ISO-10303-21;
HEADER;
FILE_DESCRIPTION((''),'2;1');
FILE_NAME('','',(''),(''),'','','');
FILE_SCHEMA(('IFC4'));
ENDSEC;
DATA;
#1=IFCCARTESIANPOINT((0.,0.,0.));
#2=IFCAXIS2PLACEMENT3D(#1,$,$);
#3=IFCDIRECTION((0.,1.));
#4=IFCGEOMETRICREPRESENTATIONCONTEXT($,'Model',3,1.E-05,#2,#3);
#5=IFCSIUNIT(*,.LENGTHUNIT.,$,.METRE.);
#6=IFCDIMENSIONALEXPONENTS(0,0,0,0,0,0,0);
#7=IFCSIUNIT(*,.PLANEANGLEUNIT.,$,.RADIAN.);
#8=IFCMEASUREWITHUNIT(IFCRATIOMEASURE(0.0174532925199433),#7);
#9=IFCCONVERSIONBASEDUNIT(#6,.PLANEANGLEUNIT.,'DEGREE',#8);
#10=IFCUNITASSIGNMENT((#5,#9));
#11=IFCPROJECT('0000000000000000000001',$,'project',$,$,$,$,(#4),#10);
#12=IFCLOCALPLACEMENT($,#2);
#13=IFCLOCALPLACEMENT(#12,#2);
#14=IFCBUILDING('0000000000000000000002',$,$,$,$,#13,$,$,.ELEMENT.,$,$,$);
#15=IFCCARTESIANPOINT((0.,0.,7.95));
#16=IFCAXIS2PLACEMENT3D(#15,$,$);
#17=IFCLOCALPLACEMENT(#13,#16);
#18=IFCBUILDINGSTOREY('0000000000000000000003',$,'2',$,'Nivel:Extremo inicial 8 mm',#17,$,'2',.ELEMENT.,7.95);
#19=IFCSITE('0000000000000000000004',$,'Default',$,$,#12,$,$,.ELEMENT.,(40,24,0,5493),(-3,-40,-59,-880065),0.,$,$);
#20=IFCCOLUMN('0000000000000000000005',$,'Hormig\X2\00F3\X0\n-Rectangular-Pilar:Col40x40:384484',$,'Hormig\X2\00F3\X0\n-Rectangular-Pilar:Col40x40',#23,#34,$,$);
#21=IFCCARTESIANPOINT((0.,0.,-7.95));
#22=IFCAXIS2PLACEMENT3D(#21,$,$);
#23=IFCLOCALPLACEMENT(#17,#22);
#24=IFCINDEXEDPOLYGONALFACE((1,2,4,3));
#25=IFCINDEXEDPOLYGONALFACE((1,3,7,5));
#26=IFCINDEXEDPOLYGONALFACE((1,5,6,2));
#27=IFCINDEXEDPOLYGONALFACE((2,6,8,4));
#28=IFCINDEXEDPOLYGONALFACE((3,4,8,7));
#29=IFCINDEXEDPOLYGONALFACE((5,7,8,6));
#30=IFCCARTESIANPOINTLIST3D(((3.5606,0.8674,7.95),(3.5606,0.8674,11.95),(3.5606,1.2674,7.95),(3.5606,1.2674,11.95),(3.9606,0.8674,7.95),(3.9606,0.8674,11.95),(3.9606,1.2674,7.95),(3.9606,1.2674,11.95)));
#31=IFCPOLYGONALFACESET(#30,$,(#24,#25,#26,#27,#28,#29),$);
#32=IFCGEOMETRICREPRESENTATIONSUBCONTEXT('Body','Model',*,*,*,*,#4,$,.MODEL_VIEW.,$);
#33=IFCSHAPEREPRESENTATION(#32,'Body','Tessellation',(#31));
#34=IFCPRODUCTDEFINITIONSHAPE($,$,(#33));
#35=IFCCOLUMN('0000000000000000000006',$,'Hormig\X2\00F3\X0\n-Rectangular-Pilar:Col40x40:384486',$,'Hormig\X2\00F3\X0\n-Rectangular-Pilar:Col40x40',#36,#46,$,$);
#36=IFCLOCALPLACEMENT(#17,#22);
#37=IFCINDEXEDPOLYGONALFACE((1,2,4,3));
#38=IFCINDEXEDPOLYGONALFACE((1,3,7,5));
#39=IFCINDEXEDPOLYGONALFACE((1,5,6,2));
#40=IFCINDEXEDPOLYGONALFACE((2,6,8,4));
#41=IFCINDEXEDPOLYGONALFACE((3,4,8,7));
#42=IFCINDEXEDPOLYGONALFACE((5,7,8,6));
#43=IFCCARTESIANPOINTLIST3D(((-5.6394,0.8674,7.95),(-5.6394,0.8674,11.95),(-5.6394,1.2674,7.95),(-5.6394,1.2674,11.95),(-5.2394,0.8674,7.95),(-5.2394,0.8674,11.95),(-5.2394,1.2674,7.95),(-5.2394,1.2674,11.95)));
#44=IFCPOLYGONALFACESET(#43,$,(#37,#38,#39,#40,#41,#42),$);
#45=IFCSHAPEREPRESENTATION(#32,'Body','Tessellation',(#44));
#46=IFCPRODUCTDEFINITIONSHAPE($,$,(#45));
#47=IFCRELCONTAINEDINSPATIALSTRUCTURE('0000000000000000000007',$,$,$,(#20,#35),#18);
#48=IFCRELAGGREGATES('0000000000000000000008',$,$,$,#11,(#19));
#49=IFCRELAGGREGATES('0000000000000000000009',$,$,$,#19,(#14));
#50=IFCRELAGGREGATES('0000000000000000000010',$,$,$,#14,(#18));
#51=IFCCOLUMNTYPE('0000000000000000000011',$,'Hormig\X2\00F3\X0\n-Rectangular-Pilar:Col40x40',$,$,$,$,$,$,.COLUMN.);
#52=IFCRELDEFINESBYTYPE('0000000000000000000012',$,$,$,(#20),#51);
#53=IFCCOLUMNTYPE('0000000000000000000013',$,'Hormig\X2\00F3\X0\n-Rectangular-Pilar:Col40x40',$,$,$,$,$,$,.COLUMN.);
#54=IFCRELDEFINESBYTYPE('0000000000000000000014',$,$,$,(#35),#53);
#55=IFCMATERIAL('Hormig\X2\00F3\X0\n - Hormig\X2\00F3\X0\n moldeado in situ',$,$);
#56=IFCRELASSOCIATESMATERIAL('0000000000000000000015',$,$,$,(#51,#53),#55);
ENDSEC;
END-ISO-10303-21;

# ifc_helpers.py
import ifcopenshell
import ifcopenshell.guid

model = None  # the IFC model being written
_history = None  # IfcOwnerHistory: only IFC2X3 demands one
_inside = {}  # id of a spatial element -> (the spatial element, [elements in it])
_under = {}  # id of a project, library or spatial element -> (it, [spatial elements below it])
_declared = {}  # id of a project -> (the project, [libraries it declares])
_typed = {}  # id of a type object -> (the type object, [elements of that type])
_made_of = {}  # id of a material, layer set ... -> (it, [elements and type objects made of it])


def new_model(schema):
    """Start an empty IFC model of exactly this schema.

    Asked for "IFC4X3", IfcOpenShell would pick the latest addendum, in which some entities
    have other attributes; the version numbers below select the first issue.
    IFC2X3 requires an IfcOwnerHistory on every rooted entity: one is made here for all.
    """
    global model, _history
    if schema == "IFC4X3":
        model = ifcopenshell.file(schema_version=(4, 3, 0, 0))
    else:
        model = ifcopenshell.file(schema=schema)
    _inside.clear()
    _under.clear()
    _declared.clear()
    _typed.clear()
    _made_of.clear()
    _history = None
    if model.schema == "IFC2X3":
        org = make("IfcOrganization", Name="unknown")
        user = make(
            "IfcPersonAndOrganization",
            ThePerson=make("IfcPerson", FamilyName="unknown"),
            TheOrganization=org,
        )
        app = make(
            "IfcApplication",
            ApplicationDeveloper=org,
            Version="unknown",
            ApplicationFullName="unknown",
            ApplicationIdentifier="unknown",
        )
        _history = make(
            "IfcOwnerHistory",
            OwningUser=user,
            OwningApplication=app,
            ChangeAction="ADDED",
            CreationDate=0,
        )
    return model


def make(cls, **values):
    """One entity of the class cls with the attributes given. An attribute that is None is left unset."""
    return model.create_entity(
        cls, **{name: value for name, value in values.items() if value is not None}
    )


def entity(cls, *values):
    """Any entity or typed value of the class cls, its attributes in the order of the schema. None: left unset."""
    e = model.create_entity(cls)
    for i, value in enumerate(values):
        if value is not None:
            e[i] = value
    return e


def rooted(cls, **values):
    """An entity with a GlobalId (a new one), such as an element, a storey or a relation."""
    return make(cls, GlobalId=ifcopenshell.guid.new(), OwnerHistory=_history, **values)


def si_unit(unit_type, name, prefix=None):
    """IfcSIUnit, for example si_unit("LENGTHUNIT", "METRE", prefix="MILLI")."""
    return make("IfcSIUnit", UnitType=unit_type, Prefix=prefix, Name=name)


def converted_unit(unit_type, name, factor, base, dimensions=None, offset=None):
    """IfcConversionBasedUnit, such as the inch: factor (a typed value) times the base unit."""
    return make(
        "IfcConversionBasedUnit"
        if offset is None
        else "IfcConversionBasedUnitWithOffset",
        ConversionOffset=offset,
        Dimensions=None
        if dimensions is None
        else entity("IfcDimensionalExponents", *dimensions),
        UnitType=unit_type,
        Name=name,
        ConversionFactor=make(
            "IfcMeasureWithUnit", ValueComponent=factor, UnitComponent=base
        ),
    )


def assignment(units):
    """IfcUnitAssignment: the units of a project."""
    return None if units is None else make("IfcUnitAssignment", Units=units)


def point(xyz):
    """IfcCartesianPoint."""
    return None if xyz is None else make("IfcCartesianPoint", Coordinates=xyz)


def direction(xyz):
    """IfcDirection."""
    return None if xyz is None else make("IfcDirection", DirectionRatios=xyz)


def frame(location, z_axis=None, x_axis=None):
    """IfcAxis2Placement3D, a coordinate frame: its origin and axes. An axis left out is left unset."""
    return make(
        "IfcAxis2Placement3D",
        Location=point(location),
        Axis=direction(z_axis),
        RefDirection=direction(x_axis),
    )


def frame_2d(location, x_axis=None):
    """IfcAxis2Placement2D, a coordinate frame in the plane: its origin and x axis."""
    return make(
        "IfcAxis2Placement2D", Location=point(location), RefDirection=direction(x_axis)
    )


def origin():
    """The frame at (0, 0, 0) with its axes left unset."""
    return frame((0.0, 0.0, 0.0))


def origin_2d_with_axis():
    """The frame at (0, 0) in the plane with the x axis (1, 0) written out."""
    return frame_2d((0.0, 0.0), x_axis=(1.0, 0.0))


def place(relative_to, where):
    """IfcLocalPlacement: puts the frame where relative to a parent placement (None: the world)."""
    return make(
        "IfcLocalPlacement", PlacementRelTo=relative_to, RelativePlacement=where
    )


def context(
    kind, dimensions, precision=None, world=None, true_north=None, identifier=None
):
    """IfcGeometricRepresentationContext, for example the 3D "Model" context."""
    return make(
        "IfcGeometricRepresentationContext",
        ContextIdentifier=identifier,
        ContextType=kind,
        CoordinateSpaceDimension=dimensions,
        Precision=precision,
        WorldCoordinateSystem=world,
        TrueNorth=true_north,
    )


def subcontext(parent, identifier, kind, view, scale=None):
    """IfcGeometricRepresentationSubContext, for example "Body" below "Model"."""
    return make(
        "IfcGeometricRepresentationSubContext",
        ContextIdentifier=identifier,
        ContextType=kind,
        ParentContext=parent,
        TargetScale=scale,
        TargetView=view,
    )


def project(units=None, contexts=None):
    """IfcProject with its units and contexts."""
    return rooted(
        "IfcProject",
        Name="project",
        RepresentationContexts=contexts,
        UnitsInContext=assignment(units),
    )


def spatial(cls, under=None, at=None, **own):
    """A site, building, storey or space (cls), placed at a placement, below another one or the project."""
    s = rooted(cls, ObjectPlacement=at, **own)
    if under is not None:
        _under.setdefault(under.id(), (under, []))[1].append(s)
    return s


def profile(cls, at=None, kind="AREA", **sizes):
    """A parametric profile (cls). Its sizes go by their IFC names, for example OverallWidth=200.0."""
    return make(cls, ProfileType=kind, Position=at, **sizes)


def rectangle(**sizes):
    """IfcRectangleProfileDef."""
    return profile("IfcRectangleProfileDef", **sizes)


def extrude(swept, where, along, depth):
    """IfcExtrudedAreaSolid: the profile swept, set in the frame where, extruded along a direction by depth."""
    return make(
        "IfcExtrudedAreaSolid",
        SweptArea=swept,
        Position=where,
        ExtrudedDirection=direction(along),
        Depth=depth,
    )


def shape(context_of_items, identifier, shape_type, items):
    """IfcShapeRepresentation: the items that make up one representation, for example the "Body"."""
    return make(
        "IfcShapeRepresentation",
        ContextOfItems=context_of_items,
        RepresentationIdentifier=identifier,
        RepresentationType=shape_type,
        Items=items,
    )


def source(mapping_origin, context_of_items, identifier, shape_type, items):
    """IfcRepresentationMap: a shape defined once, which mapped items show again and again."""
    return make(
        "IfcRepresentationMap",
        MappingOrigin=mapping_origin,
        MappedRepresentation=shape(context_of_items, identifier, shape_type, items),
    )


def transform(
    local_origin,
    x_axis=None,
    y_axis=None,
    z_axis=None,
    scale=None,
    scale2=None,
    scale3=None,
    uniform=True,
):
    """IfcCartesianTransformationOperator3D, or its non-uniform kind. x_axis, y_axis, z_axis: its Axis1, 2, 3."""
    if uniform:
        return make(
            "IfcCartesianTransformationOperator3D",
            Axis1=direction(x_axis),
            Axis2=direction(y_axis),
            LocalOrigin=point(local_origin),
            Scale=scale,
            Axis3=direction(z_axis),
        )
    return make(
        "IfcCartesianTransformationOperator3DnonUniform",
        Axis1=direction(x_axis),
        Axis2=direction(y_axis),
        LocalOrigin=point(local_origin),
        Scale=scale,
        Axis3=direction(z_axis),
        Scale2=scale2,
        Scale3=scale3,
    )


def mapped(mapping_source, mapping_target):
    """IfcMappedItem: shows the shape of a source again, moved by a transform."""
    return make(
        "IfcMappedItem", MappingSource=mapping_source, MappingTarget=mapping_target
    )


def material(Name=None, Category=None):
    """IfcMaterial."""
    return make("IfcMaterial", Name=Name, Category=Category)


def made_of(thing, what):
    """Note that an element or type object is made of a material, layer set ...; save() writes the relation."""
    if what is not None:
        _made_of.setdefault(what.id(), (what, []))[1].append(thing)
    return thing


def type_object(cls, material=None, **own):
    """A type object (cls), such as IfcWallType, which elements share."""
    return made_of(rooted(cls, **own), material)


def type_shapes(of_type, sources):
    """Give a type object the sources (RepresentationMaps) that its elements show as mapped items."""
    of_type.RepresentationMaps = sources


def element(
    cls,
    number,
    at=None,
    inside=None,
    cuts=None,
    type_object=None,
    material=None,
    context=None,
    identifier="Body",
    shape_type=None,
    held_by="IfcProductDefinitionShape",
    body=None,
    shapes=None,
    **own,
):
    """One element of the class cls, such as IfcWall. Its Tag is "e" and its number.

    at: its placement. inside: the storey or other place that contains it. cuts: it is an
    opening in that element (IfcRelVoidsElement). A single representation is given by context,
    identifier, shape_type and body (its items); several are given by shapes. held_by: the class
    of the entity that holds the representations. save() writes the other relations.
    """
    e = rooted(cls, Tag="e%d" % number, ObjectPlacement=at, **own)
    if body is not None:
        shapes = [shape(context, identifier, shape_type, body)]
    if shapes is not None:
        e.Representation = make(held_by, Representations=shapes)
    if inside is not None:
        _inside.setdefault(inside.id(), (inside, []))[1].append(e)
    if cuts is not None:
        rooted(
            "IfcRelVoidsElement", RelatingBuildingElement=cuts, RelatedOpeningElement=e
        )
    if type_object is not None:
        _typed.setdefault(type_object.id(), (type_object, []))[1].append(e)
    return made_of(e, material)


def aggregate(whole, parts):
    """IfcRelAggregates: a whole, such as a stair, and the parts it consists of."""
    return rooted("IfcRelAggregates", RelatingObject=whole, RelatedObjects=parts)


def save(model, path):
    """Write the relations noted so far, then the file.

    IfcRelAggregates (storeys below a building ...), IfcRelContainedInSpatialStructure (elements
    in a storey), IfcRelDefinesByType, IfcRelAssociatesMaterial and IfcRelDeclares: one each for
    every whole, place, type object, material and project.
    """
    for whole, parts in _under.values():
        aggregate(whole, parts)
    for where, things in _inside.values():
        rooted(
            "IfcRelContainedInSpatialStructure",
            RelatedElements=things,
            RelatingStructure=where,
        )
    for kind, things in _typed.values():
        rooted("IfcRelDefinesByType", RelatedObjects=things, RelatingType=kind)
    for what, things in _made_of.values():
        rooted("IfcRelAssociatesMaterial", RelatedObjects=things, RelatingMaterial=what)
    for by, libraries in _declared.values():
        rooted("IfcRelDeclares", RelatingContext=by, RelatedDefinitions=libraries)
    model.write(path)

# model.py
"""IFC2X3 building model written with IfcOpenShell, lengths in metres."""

from ifc_helpers import new_model, entity, si_unit, converted_unit, direction, frame, origin, origin_2d_with_axis, place, context, subcontext, project, spatial, rectangle, extrude, source, transform, mapped, material, type_object, type_shapes, element, save


model = new_model("IFC2X3")

# Units and contexts
model_context = context("Model", 3, precision=1e-05, world=origin(), true_north=direction((0.0, 1.0)))
body_context = subcontext(model_context, "Body", "Model", "MODEL_VIEW")
ifc_project = project(units=[si_unit("LENGTHUNIT", "METRE"), converted_unit("PLANEANGLEUNIT", "DEGREE", entity("IfcRatioMeasure", 0.0174532925199433), si_unit("PLANEANGLEUNIT", "RADIAN"), dimensions=[0, 0, 0, 0, 0, 0, 0])], contexts=[model_context])

# Site, building, storey
site_placement = place(None, origin())
site = spatial("IfcSite", under=ifc_project, at=site_placement, Name="Default", CompositionType="ELEMENT", RefLatitude=(40, 24, 0, 5493), RefLongitude=(-3, -40, -59, -880065), RefElevation=0.0)
building_placement = place(site_placement, origin())
building = spatial("IfcBuilding", under=site, at=building_placement, CompositionType="ELEMENT")
storey_placement = place(building_placement, frame((0.0, 0.0, 7.95)))
storey = spatial("IfcBuildingStorey", under=building, at=storey_placement, Name="2", ObjectType="Nivel:Extremo inicial 8 mm", LongName="2", CompositionType="ELEMENT", Elevation=7.95)

# Columns
ifc_material_1 = material(Name="Hormigón - Hormigón moldeado in situ")
column_type_1 = type_object("IfcColumnType", Name="Hormigón-Rectangular-Pilar:Col40x40", PredefinedType="COLUMN", material=ifc_material_1)
shared_shape_1 = source(origin(), body_context, "Body", "SweptSolid", [
    extrude(rectangle(XDim=0.4, YDim=0.4, at=origin_2d_with_axis()), frame((3.7606, 1.0674, 7.95), z_axis=(0.0, 0.0, 1.0), x_axis=(0.0, -1.0, 0.0)), (0.0, 0.0, 1.0), 4.0),
])
type_shapes(column_type_1, [shared_shape_1])
column_1_placement = place(storey_placement, frame((0.0, 0.0, -7.95)))
element("IfcColumn", 1, at=column_1_placement, inside=storey, type_object=column_type_1, Name="Hormigón-Rectangular-Pilar:Col40x40:384484", ObjectType="Hormigón-Rectangular-Pilar:Col40x40", context=body_context, shape_type="MappedRepresentation", body=[
    mapped(shared_shape_1, transform((0.0, 0.0, 0.0), scale=1.0)),
])
column_type_2 = type_object("IfcColumnType", Name="Hormigón-Rectangular-Pilar:Col40x40", PredefinedType="COLUMN", material=ifc_material_1)
shared_shape_2 = source(origin(), body_context, "Body", "SweptSolid", [
    extrude(rectangle(XDim=0.4, YDim=0.4, at=origin_2d_with_axis()), frame((-5.4394, 1.0674, 7.95), z_axis=(0.0, 0.0, 1.0), x_axis=(0.0, -1.0, 0.0)), (0.0, 0.0, 1.0), 4.0),
])
type_shapes(column_type_2, [shared_shape_2])
column_2_placement = place(storey_placement, frame((0.0, 0.0, -7.95)))
element("IfcColumn", 2, at=column_2_placement, inside=storey, type_object=column_type_2, Name="Hormigón-Rectangular-Pilar:Col40x40:384486", ObjectType="Hormigón-Rectangular-Pilar:Col40x40", context=body_context, shape_type="MappedRepresentation", body=[
    mapped(shared_shape_2, transform((0.0, 0.0, 0.0), scale=1.0)),
])

save(model, "model.ifc")
